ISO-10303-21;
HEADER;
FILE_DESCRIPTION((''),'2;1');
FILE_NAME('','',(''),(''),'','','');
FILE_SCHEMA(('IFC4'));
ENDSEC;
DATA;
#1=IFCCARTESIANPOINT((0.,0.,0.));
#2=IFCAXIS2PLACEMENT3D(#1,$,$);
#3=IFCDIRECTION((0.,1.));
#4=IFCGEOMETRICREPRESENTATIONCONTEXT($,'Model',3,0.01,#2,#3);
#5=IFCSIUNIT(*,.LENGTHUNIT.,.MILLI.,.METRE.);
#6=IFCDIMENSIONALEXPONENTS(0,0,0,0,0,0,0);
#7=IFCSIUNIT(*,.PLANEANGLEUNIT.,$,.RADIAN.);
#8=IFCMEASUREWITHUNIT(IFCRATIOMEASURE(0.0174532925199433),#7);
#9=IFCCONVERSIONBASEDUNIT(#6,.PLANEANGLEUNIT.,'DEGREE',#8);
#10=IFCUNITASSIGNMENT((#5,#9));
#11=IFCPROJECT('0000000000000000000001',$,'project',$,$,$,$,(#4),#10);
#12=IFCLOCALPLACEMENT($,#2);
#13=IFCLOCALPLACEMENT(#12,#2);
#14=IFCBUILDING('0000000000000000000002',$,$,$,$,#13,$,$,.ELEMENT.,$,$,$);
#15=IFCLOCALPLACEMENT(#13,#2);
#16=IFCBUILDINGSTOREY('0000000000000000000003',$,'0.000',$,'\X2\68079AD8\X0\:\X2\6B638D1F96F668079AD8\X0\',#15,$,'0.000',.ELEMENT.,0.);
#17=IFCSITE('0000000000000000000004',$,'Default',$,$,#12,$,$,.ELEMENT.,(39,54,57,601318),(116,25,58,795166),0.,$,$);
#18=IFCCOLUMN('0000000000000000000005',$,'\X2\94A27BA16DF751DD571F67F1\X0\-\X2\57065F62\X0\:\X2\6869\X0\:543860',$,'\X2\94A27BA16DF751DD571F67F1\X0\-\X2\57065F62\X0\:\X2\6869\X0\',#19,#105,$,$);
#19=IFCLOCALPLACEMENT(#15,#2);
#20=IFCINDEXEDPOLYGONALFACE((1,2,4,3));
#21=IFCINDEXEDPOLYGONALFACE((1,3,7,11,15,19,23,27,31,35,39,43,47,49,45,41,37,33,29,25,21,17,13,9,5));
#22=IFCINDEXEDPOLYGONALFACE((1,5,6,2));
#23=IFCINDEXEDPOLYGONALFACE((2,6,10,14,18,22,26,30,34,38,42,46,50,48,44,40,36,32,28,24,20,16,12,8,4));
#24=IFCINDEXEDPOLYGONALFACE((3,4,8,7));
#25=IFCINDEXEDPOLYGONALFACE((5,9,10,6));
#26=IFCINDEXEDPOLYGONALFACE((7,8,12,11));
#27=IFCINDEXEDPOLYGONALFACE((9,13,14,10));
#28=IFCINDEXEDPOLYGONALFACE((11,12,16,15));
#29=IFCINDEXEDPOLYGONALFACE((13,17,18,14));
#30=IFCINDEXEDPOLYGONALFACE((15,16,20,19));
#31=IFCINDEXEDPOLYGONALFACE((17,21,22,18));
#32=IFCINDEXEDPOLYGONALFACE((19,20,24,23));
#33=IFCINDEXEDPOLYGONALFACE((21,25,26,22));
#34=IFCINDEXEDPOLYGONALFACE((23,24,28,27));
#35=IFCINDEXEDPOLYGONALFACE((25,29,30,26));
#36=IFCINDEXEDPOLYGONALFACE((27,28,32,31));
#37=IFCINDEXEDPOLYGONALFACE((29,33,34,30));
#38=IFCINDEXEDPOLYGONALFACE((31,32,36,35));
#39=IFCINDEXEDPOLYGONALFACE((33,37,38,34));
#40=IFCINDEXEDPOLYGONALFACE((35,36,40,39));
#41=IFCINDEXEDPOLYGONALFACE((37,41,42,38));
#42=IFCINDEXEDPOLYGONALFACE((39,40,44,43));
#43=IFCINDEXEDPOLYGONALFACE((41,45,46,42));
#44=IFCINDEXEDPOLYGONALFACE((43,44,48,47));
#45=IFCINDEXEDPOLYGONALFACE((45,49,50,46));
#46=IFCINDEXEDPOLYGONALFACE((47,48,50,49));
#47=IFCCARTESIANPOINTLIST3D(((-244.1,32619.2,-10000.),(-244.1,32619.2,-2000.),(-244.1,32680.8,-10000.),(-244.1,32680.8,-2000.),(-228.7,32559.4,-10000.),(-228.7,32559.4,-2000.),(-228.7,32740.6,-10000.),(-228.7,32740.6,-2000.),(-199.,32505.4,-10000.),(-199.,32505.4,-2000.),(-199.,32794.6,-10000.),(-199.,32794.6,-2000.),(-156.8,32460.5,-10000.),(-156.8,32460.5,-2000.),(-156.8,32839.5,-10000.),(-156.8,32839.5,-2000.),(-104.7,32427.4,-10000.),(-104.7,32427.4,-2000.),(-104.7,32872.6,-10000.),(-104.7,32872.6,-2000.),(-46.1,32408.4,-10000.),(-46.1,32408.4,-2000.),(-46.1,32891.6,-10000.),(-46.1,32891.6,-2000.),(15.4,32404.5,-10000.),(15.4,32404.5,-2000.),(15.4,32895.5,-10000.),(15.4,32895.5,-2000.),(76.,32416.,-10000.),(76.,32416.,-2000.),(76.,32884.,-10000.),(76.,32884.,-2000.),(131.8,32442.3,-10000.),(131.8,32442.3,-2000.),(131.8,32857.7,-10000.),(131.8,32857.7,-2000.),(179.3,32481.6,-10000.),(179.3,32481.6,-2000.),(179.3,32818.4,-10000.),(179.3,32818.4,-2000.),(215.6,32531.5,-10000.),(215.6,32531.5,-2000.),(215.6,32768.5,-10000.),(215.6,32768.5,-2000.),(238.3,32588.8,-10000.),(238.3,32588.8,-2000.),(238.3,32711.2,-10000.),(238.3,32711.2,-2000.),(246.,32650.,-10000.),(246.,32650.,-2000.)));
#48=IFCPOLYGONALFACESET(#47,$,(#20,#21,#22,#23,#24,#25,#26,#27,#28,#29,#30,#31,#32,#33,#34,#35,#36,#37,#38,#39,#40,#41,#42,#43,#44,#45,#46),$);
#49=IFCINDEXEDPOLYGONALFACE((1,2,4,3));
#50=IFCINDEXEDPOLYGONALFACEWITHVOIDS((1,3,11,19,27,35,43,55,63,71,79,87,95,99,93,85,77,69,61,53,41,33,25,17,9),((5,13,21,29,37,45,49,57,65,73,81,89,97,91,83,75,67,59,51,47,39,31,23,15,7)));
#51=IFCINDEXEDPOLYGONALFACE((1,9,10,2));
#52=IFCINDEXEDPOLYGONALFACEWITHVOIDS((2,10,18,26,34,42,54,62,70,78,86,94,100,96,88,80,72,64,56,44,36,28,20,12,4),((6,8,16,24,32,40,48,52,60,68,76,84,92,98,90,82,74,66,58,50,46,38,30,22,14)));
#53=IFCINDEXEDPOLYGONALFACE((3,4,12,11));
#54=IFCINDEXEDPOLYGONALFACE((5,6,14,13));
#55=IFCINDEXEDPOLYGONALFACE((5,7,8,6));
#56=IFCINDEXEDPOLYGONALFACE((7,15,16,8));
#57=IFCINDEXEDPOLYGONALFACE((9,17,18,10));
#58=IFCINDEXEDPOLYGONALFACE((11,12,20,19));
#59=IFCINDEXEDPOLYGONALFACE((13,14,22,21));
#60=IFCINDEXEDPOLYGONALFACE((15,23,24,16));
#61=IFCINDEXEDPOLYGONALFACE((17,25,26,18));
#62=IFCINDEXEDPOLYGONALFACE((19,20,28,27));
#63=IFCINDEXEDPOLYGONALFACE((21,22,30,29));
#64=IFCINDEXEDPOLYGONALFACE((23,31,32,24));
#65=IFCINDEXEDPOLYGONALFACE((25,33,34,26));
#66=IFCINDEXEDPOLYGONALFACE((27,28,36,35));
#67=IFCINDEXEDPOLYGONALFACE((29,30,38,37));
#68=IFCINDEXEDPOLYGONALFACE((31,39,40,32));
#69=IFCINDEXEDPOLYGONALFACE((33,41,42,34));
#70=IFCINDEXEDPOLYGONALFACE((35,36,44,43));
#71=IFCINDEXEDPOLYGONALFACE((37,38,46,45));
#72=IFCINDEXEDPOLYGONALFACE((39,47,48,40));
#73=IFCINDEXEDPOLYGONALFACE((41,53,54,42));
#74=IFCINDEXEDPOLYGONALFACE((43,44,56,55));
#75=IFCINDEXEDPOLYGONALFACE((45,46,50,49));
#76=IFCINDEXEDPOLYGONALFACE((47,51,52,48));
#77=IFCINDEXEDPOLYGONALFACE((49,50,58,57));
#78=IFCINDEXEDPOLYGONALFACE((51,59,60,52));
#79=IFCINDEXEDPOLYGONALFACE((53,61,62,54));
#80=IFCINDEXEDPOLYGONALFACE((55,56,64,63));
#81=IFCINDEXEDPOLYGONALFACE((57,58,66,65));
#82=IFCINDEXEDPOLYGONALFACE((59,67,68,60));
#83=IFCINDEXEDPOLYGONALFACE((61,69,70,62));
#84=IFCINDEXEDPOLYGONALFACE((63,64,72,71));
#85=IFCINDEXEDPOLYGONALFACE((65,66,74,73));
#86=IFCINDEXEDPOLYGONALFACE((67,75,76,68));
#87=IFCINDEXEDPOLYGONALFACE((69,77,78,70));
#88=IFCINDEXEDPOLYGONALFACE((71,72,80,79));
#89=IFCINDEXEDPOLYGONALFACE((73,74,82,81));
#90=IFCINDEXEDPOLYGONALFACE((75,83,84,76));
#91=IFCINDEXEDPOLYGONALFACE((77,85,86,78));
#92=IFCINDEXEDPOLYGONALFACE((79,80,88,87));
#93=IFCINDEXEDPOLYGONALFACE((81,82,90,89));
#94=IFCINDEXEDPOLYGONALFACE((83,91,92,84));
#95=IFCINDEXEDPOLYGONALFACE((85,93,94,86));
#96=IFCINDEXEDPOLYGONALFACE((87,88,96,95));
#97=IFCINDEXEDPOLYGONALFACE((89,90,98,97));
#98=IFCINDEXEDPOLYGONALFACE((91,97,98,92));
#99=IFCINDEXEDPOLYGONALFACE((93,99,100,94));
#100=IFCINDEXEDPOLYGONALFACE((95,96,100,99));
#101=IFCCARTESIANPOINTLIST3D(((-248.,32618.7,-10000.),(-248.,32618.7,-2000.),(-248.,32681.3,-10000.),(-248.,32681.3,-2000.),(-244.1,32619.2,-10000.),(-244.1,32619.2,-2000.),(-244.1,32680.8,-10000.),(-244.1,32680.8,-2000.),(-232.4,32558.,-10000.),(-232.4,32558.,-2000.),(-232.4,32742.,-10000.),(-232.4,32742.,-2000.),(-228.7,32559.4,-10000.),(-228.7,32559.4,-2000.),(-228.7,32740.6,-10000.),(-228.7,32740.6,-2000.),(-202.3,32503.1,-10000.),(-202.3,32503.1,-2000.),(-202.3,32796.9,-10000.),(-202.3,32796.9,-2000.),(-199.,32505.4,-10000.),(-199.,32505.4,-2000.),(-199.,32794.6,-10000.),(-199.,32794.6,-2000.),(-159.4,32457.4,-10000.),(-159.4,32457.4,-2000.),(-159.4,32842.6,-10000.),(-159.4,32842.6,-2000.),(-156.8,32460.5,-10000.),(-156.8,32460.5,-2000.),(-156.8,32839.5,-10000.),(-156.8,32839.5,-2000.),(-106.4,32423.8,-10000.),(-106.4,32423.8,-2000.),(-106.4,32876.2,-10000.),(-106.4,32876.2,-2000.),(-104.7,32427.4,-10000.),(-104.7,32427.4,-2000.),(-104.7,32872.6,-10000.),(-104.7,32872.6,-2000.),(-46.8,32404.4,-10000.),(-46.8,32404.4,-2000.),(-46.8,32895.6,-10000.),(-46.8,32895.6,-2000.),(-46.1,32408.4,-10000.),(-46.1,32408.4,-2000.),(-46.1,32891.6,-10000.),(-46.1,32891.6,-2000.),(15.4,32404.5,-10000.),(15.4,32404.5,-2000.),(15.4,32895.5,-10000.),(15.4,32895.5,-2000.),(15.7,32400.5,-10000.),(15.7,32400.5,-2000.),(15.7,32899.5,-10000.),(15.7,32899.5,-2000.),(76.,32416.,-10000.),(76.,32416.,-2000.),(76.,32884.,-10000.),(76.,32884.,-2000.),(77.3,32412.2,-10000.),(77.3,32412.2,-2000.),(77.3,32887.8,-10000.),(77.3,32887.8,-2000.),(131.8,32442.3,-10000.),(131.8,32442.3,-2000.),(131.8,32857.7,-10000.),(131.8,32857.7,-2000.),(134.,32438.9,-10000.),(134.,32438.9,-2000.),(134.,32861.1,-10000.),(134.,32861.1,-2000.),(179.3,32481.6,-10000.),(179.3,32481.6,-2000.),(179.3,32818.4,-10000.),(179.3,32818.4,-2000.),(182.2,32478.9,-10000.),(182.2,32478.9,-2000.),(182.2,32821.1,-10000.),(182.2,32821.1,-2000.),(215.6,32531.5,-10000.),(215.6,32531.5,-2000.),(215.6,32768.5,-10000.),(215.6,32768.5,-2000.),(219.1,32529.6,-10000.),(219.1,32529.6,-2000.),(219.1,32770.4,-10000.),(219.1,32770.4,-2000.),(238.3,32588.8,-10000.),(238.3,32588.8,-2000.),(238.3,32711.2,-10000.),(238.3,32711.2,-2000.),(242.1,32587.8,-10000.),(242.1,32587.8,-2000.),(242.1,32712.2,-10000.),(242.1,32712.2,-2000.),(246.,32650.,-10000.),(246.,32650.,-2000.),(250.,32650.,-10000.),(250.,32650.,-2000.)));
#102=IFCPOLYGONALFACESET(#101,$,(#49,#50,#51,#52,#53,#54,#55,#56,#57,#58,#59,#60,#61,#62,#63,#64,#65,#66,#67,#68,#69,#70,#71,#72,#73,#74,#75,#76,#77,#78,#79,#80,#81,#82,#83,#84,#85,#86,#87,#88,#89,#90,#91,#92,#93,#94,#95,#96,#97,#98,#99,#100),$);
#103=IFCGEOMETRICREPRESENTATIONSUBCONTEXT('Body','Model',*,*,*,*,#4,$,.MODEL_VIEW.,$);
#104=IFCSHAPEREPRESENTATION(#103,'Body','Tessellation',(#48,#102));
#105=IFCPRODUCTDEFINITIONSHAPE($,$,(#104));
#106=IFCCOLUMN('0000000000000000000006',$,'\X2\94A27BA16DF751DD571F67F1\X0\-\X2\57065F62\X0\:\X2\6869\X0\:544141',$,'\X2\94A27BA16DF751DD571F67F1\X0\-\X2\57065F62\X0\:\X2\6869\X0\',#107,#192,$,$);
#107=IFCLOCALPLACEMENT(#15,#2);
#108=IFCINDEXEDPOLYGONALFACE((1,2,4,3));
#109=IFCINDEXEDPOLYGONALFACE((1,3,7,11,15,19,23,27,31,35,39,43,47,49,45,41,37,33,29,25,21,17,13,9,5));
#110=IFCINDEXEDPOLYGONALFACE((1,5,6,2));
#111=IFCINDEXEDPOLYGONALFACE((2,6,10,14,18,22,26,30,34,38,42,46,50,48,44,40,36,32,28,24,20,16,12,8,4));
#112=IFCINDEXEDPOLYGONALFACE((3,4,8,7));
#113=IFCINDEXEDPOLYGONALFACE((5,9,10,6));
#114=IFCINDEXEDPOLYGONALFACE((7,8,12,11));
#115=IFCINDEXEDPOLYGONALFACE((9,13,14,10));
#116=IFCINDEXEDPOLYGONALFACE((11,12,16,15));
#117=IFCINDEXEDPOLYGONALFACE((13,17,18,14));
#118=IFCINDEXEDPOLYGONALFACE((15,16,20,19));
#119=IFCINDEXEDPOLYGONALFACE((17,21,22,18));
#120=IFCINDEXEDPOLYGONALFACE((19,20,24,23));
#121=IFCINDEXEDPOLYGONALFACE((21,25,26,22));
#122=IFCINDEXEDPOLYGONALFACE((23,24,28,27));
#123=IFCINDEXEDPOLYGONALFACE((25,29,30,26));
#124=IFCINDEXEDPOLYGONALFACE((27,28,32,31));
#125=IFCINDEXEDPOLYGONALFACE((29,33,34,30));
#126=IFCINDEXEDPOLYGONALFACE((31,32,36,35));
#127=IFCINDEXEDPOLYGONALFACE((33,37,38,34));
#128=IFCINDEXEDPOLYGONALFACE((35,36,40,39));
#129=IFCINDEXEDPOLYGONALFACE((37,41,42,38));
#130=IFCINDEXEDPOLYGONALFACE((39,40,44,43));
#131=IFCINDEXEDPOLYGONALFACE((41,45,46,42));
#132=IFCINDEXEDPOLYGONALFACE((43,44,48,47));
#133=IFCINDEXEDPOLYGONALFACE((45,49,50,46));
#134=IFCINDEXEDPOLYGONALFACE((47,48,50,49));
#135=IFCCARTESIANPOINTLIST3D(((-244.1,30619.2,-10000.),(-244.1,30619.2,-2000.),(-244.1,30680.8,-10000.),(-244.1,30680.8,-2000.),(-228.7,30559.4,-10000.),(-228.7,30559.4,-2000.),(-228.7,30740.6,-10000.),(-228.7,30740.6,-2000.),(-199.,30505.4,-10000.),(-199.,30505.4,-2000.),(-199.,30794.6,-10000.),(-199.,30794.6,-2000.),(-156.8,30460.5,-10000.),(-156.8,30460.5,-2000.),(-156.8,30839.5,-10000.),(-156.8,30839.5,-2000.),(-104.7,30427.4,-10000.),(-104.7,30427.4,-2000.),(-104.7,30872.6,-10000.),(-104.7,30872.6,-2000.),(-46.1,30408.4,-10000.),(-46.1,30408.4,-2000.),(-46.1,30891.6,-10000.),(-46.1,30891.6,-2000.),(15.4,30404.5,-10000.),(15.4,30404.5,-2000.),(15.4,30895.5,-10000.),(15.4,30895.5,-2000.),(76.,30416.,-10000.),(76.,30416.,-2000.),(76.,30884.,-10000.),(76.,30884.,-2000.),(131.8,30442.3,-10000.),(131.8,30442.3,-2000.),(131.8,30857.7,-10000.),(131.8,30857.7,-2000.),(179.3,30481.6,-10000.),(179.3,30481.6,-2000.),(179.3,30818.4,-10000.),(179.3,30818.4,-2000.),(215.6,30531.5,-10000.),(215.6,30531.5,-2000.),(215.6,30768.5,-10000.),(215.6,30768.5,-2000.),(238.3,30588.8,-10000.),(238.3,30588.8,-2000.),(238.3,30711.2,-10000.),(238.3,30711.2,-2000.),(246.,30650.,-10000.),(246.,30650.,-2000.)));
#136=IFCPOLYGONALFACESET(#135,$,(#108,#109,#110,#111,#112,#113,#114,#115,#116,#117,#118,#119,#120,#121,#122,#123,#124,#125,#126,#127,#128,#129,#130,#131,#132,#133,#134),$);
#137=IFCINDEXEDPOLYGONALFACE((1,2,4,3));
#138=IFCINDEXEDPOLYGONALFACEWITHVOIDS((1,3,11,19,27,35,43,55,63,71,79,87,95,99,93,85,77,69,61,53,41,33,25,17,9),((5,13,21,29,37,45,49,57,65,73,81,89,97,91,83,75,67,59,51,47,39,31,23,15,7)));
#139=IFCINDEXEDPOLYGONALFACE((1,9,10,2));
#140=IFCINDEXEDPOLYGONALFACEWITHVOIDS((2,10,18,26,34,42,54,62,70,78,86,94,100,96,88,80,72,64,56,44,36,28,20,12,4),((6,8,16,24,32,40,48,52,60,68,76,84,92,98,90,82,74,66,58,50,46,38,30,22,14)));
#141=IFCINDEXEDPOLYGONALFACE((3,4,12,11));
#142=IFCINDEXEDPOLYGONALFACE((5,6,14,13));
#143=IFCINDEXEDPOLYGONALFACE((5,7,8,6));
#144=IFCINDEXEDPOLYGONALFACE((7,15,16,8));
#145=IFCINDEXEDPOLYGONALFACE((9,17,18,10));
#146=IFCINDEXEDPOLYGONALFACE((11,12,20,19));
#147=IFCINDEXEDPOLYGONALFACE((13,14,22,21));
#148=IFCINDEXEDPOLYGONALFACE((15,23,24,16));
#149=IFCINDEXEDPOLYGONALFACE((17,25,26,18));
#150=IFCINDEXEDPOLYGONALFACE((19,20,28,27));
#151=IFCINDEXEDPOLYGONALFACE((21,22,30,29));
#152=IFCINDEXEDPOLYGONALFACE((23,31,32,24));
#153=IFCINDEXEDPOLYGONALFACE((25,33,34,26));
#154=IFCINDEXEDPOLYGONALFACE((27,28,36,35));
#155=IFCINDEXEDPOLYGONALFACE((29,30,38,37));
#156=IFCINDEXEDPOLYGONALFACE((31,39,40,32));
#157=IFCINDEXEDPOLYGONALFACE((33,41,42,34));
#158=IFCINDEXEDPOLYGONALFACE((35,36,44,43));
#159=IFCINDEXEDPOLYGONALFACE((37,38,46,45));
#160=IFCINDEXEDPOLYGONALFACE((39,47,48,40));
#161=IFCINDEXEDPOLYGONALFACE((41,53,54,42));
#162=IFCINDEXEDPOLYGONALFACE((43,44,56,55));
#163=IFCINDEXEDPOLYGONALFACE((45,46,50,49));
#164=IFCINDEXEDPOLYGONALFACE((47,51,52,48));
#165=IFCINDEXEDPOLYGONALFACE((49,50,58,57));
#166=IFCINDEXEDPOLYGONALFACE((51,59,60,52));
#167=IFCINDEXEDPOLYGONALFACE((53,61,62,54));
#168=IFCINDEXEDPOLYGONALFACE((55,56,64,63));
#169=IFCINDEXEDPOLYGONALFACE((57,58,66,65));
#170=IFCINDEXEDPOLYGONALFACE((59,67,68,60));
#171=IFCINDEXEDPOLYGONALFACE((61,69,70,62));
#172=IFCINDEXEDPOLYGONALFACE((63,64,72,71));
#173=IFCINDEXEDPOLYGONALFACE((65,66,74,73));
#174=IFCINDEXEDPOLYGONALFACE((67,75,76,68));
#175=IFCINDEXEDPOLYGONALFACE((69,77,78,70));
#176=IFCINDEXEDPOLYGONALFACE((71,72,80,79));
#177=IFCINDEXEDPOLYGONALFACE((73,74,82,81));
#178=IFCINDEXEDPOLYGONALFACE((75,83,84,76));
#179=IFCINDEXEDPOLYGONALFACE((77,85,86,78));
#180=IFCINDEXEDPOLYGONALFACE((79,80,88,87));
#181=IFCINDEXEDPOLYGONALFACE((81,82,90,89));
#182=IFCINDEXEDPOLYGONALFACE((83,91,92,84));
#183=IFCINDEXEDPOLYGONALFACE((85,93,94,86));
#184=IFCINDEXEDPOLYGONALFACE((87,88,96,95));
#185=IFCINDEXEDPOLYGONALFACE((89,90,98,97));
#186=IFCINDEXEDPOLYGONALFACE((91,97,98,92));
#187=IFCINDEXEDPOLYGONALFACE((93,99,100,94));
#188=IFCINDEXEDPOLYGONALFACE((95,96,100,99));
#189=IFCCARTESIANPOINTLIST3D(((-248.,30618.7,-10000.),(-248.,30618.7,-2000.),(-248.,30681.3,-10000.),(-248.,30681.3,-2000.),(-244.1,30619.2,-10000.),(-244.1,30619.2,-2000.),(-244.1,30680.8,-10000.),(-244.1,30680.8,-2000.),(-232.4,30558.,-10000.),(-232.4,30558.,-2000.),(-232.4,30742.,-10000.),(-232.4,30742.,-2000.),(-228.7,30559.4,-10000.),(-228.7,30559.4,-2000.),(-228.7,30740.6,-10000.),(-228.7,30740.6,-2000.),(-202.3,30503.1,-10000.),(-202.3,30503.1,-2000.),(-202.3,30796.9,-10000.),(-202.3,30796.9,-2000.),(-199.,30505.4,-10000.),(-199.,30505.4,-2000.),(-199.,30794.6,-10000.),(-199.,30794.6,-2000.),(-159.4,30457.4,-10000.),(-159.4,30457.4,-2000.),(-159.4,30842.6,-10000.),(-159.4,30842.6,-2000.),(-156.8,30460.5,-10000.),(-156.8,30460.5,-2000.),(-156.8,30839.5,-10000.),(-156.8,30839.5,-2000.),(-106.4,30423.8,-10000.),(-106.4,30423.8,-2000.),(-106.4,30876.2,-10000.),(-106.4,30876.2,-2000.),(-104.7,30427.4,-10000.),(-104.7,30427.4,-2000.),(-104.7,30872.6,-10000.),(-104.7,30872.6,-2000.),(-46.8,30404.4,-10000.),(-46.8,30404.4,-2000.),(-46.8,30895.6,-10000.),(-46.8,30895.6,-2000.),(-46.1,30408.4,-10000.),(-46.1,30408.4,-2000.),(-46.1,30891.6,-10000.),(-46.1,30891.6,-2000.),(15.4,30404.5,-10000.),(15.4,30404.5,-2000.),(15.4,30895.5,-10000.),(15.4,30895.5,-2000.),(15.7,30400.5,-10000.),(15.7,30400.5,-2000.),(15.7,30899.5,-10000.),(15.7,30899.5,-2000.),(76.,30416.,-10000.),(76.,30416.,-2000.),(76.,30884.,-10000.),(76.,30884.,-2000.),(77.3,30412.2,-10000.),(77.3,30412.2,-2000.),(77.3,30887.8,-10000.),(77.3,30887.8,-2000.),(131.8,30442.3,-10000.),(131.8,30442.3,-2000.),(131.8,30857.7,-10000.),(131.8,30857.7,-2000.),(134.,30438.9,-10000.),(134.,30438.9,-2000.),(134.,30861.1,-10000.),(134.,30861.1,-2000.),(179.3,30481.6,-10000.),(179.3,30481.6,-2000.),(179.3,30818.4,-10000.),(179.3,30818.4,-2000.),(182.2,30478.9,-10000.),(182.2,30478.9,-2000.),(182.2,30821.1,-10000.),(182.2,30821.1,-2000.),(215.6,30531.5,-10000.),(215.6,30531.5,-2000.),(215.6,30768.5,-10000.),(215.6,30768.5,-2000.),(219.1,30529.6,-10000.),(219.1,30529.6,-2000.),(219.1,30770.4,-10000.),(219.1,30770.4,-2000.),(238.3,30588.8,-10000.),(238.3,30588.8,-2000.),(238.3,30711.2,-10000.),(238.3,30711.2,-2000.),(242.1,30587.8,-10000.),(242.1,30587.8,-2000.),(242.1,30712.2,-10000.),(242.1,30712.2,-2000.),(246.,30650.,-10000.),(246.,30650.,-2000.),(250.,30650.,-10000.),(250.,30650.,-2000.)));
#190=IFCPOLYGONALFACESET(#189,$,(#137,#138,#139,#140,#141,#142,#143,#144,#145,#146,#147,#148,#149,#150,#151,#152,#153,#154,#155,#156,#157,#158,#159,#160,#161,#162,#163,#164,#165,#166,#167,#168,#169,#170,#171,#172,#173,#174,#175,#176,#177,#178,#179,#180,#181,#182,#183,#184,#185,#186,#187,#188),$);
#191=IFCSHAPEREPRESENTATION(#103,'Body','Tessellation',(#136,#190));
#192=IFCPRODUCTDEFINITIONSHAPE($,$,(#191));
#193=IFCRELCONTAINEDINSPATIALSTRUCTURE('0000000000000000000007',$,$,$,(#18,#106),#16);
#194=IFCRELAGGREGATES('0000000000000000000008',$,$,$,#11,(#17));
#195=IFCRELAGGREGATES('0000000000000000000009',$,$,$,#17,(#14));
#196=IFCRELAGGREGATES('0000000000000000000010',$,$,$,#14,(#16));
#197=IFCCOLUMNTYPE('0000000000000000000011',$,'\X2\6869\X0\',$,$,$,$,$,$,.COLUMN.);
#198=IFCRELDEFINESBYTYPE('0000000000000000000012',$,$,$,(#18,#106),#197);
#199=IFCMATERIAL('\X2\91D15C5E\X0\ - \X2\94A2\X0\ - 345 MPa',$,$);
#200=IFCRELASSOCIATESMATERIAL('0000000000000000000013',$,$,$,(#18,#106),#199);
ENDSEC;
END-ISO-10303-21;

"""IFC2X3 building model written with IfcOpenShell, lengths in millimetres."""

from ifc_helpers import new_model, entity, si_unit, converted_unit, direction, frame, frame_2d, origin, place, context, subcontext, project, spatial, circle, hollow_circle, extrude, source, transform, mapped, material, type_object, type_shapes, element, save


model = new_model("IFC2X3")

# Units and contexts
model_context = context("Model", 3, precision=0.01, world=origin(), true_north=direction((0.0, 1.0)))
body_context = subcontext(model_context, "Body", "Model", "MODEL_VIEW")
ifc_project = project(units=[si_unit("LENGTHUNIT", "METRE", prefix="MILLI"), converted_unit("PLANEANGLEUNIT", "DEGREE", entity("IfcRatioMeasure", 0.0174532925199433), si_unit("PLANEANGLEUNIT", "RADIAN"), dimensions=[0, 0, 0, 0, 0, 0, 0])], contexts=[model_context])

# Site, building, storey
site_placement = place(None, origin())
site = spatial("IfcSite", under=ifc_project, at=site_placement, Name="Default", CompositionType="ELEMENT", RefLatitude=(39, 54, 57, 601318), RefLongitude=(116, 25, 58, 795166), RefElevation=0.0)
building_placement = place(site_placement, origin())
building = spatial("IfcBuilding", under=site, at=building_placement, CompositionType="ELEMENT")
storey_placement = place(building_placement, origin())
storey = spatial("IfcBuildingStorey", under=building, at=storey_placement, Name="0.000", ObjectType="标高:正负零标高", LongName="0.000", CompositionType="ELEMENT", Elevation=0.0)

# Columns
ifc_material_1 = material(Name="金属 - 钢 - 345 MPa")
column_type_1 = type_object("IfcColumnType", Name="桩", PredefinedType="COLUMN")
shared_shape_1 = source(origin(), body_context, "Body", "SweptSolid", [
    extrude(circle(Radius=246.0, at=frame_2d((0.0, 0.0), x_axis=(1.0, 0.0))), frame((0.0, 0.0, -10000.0)), (0.0, 0.0, 1.0), 8000.0),
    extrude(hollow_circle(Radius=250.0, WallThickness=4.0, at=frame_2d((0.0, 0.0), x_axis=(1.0, 0.0))), frame((0.0, 0.0, -10000.0)), (0.0, 0.0, 1.0), 8000.0),
])
type_shapes(column_type_1, [shared_shape_1])
for number, where, name in (
    (1, (0.0, 32650.0, 0.0), "钢管混凝土柱-圆形:桩:543860"),
    (2, (0.0, 30650.0, 0.0), "钢管混凝土柱-圆形:桩:544141"),
):
    element("IfcColumn", number, at=place(storey_placement, frame(where)), inside=storey, type_object=column_type_1, material=ifc_material_1, Name=name, ObjectType="钢管混凝土柱-圆形:桩", context=body_context, shape_type="MappedRepresentation", body=[
        mapped(shared_shape_1, transform((0.0, 0.0, 0.0), scale=1.0)),
    ])

save(model, "model.ifc")
